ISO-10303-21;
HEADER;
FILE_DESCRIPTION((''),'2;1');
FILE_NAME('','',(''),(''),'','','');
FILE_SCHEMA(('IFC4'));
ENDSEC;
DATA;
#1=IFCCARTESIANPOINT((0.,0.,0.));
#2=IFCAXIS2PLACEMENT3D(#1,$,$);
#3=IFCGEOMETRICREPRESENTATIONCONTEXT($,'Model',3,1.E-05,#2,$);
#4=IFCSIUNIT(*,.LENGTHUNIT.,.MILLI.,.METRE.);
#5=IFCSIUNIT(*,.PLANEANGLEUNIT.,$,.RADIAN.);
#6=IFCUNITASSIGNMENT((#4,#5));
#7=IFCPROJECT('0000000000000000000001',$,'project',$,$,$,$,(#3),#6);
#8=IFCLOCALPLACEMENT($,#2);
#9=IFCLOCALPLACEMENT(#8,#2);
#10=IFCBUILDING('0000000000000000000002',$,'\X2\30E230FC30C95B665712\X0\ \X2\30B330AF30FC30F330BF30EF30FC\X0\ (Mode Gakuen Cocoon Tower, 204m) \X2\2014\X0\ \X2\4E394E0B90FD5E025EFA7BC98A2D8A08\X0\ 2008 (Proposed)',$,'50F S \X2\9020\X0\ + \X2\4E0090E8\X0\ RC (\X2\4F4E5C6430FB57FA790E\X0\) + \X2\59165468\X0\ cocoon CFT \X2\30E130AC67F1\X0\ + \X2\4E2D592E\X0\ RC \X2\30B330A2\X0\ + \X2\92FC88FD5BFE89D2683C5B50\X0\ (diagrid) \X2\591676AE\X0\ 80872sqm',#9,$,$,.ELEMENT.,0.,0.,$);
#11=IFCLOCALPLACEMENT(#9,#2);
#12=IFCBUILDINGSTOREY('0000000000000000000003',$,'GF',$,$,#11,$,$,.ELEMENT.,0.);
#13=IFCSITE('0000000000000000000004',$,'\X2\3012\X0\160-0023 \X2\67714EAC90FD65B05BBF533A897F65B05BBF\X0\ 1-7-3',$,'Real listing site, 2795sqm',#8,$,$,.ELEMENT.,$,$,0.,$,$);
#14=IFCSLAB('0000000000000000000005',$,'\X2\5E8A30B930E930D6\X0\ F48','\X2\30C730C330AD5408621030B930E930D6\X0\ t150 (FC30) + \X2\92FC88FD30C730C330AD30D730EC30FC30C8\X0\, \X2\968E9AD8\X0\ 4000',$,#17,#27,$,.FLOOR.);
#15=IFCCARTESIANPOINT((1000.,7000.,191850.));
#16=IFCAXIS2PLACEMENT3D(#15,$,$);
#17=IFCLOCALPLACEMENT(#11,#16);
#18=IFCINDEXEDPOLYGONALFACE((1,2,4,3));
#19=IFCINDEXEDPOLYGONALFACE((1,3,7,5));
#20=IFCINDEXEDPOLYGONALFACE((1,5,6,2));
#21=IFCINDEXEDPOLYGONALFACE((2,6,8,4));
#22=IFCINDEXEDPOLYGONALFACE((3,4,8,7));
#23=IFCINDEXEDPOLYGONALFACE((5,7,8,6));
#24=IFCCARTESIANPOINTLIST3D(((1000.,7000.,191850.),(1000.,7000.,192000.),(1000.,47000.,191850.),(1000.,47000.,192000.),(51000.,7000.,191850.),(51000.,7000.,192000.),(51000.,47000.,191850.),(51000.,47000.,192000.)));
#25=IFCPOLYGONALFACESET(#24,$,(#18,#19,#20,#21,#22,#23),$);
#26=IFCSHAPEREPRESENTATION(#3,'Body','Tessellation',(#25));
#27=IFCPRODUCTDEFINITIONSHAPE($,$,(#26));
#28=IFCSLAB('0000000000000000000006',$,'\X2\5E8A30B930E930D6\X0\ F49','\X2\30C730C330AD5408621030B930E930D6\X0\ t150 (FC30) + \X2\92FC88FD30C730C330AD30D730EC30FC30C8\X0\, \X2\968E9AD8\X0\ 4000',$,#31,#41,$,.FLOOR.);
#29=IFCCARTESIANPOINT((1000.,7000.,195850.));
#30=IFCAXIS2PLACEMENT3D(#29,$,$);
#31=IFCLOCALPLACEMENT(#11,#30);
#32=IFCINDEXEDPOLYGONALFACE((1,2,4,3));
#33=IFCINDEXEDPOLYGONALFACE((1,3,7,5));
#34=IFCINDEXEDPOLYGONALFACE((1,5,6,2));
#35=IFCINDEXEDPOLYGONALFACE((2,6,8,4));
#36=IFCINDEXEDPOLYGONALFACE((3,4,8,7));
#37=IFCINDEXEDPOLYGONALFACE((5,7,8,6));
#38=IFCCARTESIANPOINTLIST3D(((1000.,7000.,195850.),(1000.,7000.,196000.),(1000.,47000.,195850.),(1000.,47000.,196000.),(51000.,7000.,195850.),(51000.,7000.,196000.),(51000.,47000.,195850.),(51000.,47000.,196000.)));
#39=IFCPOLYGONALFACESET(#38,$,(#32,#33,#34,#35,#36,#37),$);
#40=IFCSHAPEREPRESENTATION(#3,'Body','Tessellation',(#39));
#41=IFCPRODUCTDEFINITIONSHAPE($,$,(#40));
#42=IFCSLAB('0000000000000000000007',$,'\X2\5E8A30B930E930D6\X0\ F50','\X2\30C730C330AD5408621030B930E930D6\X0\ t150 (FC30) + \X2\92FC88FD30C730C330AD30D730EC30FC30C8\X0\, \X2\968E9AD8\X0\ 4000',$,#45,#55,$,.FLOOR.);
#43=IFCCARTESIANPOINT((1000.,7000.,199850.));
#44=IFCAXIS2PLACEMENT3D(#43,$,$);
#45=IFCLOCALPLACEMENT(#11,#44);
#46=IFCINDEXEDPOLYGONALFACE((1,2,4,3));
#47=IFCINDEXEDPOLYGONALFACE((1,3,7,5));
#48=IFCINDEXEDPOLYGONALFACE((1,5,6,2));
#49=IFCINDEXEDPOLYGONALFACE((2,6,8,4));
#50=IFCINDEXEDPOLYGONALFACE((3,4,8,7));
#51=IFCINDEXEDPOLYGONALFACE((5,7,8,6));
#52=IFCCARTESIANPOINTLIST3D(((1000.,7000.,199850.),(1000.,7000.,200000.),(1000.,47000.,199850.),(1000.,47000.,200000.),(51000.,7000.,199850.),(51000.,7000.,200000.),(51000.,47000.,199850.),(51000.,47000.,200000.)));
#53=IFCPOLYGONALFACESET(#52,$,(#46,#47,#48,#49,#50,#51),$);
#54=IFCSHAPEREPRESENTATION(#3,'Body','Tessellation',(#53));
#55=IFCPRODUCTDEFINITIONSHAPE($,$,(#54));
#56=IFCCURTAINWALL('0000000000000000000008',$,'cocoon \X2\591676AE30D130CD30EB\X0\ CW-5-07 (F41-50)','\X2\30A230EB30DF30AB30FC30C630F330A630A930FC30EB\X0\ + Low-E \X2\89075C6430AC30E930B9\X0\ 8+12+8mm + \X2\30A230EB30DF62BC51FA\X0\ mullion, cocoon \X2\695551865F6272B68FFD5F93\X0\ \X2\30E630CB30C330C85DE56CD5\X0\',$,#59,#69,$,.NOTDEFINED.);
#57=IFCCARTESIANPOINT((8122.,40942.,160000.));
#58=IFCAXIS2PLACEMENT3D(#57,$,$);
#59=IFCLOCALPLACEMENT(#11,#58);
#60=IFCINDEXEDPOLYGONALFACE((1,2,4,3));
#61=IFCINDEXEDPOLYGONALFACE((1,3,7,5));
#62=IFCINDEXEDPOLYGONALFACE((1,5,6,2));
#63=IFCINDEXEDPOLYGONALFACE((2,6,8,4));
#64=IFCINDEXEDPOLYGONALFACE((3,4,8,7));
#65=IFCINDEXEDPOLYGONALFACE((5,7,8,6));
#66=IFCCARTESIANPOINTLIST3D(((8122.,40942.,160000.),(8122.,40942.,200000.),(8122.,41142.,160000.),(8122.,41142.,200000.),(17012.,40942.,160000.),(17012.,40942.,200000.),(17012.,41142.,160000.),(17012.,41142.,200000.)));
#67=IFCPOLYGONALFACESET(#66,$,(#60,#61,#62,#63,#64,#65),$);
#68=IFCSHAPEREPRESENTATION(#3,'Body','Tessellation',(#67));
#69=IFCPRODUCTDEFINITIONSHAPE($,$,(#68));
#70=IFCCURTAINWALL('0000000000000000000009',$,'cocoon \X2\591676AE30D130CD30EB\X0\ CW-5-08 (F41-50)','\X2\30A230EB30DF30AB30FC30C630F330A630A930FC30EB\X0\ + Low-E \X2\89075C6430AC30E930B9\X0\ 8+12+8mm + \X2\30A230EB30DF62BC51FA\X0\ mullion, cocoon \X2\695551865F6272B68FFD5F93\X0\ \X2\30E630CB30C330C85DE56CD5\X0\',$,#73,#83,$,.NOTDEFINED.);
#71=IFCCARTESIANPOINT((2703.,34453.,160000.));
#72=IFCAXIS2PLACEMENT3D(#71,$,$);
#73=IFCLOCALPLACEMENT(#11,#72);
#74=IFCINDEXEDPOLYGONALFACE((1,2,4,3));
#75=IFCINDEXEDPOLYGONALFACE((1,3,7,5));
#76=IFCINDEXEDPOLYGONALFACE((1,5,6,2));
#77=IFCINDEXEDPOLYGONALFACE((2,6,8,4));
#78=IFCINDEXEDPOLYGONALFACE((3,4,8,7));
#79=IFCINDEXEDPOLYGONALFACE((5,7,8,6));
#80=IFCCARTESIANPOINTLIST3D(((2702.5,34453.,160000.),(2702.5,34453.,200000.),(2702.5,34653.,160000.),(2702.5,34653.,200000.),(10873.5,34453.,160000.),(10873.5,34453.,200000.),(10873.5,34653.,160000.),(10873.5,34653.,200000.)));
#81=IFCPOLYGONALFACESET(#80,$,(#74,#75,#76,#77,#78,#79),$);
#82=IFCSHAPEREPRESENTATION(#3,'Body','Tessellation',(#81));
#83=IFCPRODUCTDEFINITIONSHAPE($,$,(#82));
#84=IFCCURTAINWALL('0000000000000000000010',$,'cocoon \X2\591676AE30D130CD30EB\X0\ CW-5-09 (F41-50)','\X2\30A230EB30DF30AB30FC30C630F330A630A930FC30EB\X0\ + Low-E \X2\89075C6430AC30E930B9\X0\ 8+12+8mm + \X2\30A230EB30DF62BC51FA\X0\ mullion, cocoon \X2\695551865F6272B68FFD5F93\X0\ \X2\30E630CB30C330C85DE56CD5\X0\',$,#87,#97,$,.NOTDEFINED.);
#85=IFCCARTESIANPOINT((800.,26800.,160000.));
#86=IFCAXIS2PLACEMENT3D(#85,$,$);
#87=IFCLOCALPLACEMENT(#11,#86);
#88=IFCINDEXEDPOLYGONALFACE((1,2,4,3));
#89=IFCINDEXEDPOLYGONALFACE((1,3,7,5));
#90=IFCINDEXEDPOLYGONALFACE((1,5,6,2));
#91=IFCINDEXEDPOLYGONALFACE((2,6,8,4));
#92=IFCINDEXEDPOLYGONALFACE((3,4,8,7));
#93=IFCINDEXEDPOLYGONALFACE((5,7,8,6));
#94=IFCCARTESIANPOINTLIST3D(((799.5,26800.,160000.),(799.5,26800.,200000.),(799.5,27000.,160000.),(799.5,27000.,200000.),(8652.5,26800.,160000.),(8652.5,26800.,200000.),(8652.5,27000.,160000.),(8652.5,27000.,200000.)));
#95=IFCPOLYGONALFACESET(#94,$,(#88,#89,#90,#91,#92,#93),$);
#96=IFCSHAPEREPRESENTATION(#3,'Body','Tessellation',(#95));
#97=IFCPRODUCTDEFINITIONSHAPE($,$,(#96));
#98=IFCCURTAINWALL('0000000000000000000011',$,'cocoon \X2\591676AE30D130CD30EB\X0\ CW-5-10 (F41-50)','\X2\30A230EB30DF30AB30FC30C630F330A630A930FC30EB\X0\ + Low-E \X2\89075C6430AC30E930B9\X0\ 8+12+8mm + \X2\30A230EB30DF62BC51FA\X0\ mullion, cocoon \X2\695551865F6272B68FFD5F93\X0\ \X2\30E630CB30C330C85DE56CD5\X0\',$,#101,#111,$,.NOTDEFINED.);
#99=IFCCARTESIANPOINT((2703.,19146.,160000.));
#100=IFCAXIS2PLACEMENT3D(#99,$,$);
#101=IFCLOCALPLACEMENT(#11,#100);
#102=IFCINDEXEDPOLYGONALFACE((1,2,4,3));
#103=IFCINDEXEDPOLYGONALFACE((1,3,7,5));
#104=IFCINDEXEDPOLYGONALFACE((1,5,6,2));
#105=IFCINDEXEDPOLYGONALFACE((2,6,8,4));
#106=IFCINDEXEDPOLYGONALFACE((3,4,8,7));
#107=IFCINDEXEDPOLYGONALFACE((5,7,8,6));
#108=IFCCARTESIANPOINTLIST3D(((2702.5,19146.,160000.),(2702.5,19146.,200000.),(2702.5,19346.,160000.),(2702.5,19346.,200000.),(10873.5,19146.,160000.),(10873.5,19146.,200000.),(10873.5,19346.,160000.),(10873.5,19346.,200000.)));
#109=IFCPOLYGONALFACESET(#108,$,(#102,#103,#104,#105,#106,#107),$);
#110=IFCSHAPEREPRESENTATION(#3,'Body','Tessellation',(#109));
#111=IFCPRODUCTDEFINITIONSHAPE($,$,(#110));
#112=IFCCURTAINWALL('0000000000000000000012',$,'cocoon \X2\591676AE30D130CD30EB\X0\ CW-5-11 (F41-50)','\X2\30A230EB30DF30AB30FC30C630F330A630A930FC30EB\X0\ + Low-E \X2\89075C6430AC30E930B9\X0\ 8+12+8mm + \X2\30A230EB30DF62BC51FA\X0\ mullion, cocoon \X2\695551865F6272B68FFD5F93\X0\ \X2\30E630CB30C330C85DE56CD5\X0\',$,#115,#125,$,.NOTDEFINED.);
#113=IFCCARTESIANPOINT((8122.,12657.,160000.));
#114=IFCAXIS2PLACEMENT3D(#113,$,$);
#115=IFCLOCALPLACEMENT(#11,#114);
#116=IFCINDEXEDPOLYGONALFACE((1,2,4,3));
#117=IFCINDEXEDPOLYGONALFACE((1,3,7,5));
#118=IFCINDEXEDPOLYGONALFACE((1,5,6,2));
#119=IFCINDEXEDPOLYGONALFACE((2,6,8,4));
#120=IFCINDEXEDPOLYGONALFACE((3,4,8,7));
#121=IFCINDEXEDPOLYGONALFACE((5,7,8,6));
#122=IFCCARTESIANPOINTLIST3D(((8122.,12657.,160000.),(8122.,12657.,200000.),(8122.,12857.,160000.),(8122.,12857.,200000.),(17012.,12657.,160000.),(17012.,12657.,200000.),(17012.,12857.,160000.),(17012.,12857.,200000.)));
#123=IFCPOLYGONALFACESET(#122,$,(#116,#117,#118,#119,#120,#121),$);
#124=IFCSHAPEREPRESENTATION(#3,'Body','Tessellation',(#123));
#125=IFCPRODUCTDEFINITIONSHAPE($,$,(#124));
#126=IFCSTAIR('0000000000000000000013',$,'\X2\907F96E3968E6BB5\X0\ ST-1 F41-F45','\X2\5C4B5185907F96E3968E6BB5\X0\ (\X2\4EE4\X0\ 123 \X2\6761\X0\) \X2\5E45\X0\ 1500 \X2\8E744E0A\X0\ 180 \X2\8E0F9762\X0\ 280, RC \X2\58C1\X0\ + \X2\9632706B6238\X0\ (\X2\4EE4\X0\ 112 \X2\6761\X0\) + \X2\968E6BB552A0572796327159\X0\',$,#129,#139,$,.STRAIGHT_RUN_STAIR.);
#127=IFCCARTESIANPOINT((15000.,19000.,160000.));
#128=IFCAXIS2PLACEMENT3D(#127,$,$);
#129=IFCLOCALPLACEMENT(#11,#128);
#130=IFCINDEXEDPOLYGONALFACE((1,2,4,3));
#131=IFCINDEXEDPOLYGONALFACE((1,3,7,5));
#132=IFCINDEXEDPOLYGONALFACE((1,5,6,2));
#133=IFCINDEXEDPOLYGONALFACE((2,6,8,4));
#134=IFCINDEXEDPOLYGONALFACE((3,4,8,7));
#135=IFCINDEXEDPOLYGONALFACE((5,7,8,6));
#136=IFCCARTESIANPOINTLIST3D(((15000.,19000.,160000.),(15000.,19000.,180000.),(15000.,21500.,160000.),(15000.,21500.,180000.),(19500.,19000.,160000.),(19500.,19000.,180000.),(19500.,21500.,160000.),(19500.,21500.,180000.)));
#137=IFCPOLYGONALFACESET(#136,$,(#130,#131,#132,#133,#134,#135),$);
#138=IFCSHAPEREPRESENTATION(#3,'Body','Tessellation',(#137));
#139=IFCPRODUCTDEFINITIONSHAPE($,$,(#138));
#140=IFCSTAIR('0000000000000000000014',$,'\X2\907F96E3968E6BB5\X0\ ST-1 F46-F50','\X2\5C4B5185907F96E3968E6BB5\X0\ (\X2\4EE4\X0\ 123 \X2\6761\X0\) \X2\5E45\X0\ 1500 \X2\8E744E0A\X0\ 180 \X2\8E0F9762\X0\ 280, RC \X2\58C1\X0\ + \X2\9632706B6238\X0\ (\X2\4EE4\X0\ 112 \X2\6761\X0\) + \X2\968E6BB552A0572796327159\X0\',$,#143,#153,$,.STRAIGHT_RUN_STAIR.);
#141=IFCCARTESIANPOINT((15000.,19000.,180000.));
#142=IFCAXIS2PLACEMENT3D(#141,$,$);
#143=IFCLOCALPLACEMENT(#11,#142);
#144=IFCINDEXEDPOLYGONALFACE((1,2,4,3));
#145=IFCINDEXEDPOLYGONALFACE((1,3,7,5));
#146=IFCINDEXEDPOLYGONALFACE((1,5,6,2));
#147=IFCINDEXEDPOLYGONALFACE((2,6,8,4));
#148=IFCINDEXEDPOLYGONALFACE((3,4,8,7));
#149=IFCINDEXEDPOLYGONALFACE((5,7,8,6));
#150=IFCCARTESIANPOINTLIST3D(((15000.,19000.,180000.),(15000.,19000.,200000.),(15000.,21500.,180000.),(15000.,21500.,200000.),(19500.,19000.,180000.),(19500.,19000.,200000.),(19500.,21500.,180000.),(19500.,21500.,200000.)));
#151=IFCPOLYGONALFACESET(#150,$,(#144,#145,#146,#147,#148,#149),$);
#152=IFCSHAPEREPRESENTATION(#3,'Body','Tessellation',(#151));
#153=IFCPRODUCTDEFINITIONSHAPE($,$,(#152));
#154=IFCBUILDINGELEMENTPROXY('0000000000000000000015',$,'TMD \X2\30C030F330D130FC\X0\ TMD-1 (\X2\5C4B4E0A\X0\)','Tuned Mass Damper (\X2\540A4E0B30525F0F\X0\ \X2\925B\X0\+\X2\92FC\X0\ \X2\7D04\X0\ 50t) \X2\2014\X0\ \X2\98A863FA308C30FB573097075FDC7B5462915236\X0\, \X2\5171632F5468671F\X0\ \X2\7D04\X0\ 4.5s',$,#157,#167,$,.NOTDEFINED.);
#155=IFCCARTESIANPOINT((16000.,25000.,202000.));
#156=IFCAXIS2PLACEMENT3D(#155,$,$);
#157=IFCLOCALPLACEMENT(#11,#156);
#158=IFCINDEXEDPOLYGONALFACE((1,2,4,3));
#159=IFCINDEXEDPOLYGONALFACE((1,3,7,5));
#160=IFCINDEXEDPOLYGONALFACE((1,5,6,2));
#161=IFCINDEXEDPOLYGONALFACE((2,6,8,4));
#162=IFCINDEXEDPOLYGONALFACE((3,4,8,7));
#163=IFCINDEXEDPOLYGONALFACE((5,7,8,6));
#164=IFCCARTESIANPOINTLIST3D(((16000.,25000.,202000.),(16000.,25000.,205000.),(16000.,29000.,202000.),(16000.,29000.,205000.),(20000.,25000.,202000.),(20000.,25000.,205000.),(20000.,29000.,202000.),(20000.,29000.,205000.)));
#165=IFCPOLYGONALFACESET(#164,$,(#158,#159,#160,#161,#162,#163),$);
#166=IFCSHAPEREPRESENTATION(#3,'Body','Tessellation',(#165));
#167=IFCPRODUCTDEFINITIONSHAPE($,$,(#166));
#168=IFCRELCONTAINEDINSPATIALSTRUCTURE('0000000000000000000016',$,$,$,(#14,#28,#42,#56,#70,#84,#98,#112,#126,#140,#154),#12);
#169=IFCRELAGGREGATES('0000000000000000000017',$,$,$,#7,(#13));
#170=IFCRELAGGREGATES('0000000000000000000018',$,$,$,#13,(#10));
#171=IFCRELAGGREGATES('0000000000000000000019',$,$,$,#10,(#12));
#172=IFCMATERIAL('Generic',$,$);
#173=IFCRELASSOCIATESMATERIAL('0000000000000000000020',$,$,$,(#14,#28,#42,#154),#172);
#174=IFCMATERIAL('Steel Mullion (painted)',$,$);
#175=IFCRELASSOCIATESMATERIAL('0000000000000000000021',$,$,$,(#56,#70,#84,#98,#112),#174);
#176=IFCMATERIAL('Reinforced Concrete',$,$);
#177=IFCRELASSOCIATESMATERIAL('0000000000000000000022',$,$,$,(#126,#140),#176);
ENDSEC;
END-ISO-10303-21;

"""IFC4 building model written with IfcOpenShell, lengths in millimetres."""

from ifc_helpers import new_model, si_unit, frame, frame_2d, origin, place, context, project, spatial, rectangle, extrude, material, element, save


model = new_model("IFC4")

# Units and contexts
model_context = context("Model", 3, precision=1e-05, world=origin())
ifc_project = project(units=[si_unit("LENGTHUNIT", "METRE", prefix="MILLI"), si_unit("PLANEANGLEUNIT", "RADIAN")], contexts=[model_context])

# Site, building, storey
site_placement = place(None, origin())
site = spatial("IfcSite", under=ifc_project, at=site_placement, Name="〒160-0023 東京都新宿区西新宿 1-7-3", ObjectType="Real listing site, 2795sqm", CompositionType="ELEMENT", RefElevation=0.0)
building_placement = place(site_placement, origin())
building = spatial("IfcBuilding", under=site, at=building_placement, Name="モード学園 コクーンタワー (Mode Gakuen Cocoon Tower, 204m) — 丹下都市建築設計 2008 (Proposed)", ObjectType="50F S 造 + 一部 RC (低層・基礎) + 外周 cocoon CFT メガ柱 + 中央 RC コア + 鋼製対角格子 (diagrid) 外皮 80872sqm", CompositionType="ELEMENT", ElevationOfRefHeight=0.0, ElevationOfTerrain=0.0)
storey_placement = place(building_placement, origin())
storey = spatial("IfcBuildingStorey", under=building, at=storey_placement, Name="GF", CompositionType="ELEMENT", Elevation=0.0)

# Shared definitions
ifc_material_1 = material(Name="Generic")

# Slabs
slab_1_placement = place(storey_placement, frame((1000.0, 7000.0, 191850.0)))
element("IfcSlab", 1, at=slab_1_placement, inside=storey, material=ifc_material_1, Name="床スラブ F48", Description="デッキ合成スラブ t150 (FC30) + 鋼製デッキプレート, 階高 4000", PredefinedType="FLOOR", context=model_context, shape_type="SweptSolid", body=[
    extrude(rectangle(XDim=50000.0, YDim=40000.0, at=frame_2d((25000.0, 20000.0))), frame((1000.0, 7000.0, 191850.0)), (0.0, 0.0, 1.0), 150.0),
])
slab_2_placement = place(storey_placement, frame((1000.0, 7000.0, 195850.0)))
element("IfcSlab", 2, at=slab_2_placement, inside=storey, material=ifc_material_1, Name="床スラブ F49", Description="デッキ合成スラブ t150 (FC30) + 鋼製デッキプレート, 階高 4000", PredefinedType="FLOOR", context=model_context, shape_type="SweptSolid", body=[
    extrude(rectangle(XDim=50000.0, YDim=40000.0, at=frame_2d((25000.0, 20000.0))), frame((1000.0, 7000.0, 195850.0)), (0.0, 0.0, 1.0), 150.0),
])
slab_3_placement = place(storey_placement, frame((1000.0, 7000.0, 199850.0)))
element("IfcSlab", 3, at=slab_3_placement, inside=storey, material=ifc_material_1, Name="床スラブ F50", Description="デッキ合成スラブ t150 (FC30) + 鋼製デッキプレート, 階高 4000", PredefinedType="FLOOR", context=model_context, shape_type="SweptSolid", body=[
    extrude(rectangle(XDim=50000.0, YDim=40000.0, at=frame_2d((25000.0, 20000.0))), frame((1000.0, 7000.0, 199850.0)), (0.0, 0.0, 1.0), 150.0),
])

# Curtain walls
ifc_material_2 = material(Name="Steel Mullion (painted)")
curtain_wall_1_placement = place(storey_placement, frame((8122.0, 40942.0, 160000.0)))
element("IfcCurtainWall", 4, at=curtain_wall_1_placement, inside=storey, material=ifc_material_2, Name="cocoon 外皮パネル CW-5-07 (F41-50)", Description="アルミカーテンウォール + Low-E 複層ガラス 8+12+8mm + アルミ押出 mullion, cocoon 楕円形状追従 ユニット工法", PredefinedType="NOTDEFINED", context=model_context, shape_type="SweptSolid", body=[
    extrude(rectangle(XDim=8890.0, YDim=200.0, at=frame_2d((4445.0, 100.0))), frame((8122.0, 40942.0, 160000.0)), (0.0, 0.0, 1.0), 40000.0),
])
curtain_wall_2_placement = place(storey_placement, frame((2703.0, 34453.0, 160000.0)))
element("IfcCurtainWall", 5, at=curtain_wall_2_placement, inside=storey, material=ifc_material_2, Name="cocoon 外皮パネル CW-5-08 (F41-50)", Description="アルミカーテンウォール + Low-E 複層ガラス 8+12+8mm + アルミ押出 mullion, cocoon 楕円形状追従 ユニット工法", PredefinedType="NOTDEFINED", context=model_context, shape_type="SweptSolid", body=[
    extrude(rectangle(XDim=8171.0, YDim=200.0, at=frame_2d((4085.0, 100.0))), frame((2703.0, 34453.0, 160000.0)), (0.0, 0.0, 1.0), 40000.0),
])
curtain_wall_3_placement = place(storey_placement, frame((800.0, 26800.0, 160000.0)))
element("IfcCurtainWall", 6, at=curtain_wall_3_placement, inside=storey, material=ifc_material_2, Name="cocoon 外皮パネル CW-5-09 (F41-50)", Description="アルミカーテンウォール + Low-E 複層ガラス 8+12+8mm + アルミ押出 mullion, cocoon 楕円形状追従 ユニット工法", PredefinedType="NOTDEFINED", context=model_context, shape_type="SweptSolid", body=[
    extrude(rectangle(XDim=7853.0, YDim=200.0, at=frame_2d((3926.0, 100.0))), frame((800.0, 26800.0, 160000.0)), (0.0, 0.0, 1.0), 40000.0),
])
curtain_wall_4_placement = place(storey_placement, frame((2703.0, 19146.0, 160000.0)))
element("IfcCurtainWall", 7, at=curtain_wall_4_placement, inside=storey, material=ifc_material_2, Name="cocoon 外皮パネル CW-5-10 (F41-50)", Description="アルミカーテンウォール + Low-E 複層ガラス 8+12+8mm + アルミ押出 mullion, cocoon 楕円形状追従 ユニット工法", PredefinedType="NOTDEFINED", context=model_context, shape_type="SweptSolid", body=[
    extrude(rectangle(XDim=8171.0, YDim=200.0, at=frame_2d((4085.0, 100.0))), frame((2703.0, 19146.0, 160000.0)), (0.0, 0.0, 1.0), 40000.0),
])
curtain_wall_5_placement = place(storey_placement, frame((8122.0, 12657.0, 160000.0)))
element("IfcCurtainWall", 8, at=curtain_wall_5_placement, inside=storey, material=ifc_material_2, Name="cocoon 外皮パネル CW-5-11 (F41-50)", Description="アルミカーテンウォール + Low-E 複層ガラス 8+12+8mm + アルミ押出 mullion, cocoon 楕円形状追従 ユニット工法", PredefinedType="NOTDEFINED", context=model_context, shape_type="SweptSolid", body=[
    extrude(rectangle(XDim=8890.0, YDim=200.0, at=frame_2d((4445.0, 100.0))), frame((8122.0, 12657.0, 160000.0)), (0.0, 0.0, 1.0), 40000.0),
])

# Stairs
ifc_material_3 = material(Name="Reinforced Concrete")
stair_1_placement = place(storey_placement, frame((15000.0, 19000.0, 160000.0)))
element("IfcStair", 9, at=stair_1_placement, inside=storey, material=ifc_material_3, Name="避難階段 ST-1 F41-F45", Description="屋内避難階段 (令 123 条) 幅 1500 蹴上 180 踏面 280, RC 壁 + 防火戸 (令 112 条) + 階段加圧防煙", PredefinedType="STRAIGHT_RUN_STAIR", context=model_context, shape_type="SweptSolid", body=[
    extrude(rectangle(XDim=4500.0, YDim=2500.0, at=frame_2d((2250.0, 1250.0))), frame((15000.0, 19000.0, 160000.0)), (0.0, 0.0, 1.0), 20000.0),
])
stair_2_placement = place(storey_placement, frame((15000.0, 19000.0, 180000.0)))
element("IfcStair", 10, at=stair_2_placement, inside=storey, material=ifc_material_3, Name="避難階段 ST-1 F46-F50", Description="屋内避難階段 (令 123 条) 幅 1500 蹴上 180 踏面 280, RC 壁 + 防火戸 (令 112 条) + 階段加圧防煙", PredefinedType="STRAIGHT_RUN_STAIR", context=model_context, shape_type="SweptSolid", body=[
    extrude(rectangle(XDim=4500.0, YDim=2500.0, at=frame_2d((2250.0, 1250.0))), frame((15000.0, 19000.0, 180000.0)), (0.0, 0.0, 1.0), 20000.0),
])

# Building element proxy
proxy_placement = place(storey_placement, frame((16000.0, 25000.0, 202000.0)))
element("IfcBuildingElementProxy", 11, at=proxy_placement, inside=storey, material=ifc_material_1, Name="TMD ダンパー TMD-1 (屋上)", Description="Tuned Mass Damper (吊下げ式 鉛+鋼 約 50t) — 風揺れ・地震応答抑制, 共振周期 約 4.5s", PredefinedType="NOTDEFINED", context=model_context, shape_type="SweptSolid", body=[
    extrude(rectangle(XDim=4000.0, YDim=4000.0, at=frame_2d((2000.0, 2000.0))), frame((16000.0, 25000.0, 202000.0)), (0.0, 0.0, 1.0), 3000.0),
])

save(model, "model.ifc")
